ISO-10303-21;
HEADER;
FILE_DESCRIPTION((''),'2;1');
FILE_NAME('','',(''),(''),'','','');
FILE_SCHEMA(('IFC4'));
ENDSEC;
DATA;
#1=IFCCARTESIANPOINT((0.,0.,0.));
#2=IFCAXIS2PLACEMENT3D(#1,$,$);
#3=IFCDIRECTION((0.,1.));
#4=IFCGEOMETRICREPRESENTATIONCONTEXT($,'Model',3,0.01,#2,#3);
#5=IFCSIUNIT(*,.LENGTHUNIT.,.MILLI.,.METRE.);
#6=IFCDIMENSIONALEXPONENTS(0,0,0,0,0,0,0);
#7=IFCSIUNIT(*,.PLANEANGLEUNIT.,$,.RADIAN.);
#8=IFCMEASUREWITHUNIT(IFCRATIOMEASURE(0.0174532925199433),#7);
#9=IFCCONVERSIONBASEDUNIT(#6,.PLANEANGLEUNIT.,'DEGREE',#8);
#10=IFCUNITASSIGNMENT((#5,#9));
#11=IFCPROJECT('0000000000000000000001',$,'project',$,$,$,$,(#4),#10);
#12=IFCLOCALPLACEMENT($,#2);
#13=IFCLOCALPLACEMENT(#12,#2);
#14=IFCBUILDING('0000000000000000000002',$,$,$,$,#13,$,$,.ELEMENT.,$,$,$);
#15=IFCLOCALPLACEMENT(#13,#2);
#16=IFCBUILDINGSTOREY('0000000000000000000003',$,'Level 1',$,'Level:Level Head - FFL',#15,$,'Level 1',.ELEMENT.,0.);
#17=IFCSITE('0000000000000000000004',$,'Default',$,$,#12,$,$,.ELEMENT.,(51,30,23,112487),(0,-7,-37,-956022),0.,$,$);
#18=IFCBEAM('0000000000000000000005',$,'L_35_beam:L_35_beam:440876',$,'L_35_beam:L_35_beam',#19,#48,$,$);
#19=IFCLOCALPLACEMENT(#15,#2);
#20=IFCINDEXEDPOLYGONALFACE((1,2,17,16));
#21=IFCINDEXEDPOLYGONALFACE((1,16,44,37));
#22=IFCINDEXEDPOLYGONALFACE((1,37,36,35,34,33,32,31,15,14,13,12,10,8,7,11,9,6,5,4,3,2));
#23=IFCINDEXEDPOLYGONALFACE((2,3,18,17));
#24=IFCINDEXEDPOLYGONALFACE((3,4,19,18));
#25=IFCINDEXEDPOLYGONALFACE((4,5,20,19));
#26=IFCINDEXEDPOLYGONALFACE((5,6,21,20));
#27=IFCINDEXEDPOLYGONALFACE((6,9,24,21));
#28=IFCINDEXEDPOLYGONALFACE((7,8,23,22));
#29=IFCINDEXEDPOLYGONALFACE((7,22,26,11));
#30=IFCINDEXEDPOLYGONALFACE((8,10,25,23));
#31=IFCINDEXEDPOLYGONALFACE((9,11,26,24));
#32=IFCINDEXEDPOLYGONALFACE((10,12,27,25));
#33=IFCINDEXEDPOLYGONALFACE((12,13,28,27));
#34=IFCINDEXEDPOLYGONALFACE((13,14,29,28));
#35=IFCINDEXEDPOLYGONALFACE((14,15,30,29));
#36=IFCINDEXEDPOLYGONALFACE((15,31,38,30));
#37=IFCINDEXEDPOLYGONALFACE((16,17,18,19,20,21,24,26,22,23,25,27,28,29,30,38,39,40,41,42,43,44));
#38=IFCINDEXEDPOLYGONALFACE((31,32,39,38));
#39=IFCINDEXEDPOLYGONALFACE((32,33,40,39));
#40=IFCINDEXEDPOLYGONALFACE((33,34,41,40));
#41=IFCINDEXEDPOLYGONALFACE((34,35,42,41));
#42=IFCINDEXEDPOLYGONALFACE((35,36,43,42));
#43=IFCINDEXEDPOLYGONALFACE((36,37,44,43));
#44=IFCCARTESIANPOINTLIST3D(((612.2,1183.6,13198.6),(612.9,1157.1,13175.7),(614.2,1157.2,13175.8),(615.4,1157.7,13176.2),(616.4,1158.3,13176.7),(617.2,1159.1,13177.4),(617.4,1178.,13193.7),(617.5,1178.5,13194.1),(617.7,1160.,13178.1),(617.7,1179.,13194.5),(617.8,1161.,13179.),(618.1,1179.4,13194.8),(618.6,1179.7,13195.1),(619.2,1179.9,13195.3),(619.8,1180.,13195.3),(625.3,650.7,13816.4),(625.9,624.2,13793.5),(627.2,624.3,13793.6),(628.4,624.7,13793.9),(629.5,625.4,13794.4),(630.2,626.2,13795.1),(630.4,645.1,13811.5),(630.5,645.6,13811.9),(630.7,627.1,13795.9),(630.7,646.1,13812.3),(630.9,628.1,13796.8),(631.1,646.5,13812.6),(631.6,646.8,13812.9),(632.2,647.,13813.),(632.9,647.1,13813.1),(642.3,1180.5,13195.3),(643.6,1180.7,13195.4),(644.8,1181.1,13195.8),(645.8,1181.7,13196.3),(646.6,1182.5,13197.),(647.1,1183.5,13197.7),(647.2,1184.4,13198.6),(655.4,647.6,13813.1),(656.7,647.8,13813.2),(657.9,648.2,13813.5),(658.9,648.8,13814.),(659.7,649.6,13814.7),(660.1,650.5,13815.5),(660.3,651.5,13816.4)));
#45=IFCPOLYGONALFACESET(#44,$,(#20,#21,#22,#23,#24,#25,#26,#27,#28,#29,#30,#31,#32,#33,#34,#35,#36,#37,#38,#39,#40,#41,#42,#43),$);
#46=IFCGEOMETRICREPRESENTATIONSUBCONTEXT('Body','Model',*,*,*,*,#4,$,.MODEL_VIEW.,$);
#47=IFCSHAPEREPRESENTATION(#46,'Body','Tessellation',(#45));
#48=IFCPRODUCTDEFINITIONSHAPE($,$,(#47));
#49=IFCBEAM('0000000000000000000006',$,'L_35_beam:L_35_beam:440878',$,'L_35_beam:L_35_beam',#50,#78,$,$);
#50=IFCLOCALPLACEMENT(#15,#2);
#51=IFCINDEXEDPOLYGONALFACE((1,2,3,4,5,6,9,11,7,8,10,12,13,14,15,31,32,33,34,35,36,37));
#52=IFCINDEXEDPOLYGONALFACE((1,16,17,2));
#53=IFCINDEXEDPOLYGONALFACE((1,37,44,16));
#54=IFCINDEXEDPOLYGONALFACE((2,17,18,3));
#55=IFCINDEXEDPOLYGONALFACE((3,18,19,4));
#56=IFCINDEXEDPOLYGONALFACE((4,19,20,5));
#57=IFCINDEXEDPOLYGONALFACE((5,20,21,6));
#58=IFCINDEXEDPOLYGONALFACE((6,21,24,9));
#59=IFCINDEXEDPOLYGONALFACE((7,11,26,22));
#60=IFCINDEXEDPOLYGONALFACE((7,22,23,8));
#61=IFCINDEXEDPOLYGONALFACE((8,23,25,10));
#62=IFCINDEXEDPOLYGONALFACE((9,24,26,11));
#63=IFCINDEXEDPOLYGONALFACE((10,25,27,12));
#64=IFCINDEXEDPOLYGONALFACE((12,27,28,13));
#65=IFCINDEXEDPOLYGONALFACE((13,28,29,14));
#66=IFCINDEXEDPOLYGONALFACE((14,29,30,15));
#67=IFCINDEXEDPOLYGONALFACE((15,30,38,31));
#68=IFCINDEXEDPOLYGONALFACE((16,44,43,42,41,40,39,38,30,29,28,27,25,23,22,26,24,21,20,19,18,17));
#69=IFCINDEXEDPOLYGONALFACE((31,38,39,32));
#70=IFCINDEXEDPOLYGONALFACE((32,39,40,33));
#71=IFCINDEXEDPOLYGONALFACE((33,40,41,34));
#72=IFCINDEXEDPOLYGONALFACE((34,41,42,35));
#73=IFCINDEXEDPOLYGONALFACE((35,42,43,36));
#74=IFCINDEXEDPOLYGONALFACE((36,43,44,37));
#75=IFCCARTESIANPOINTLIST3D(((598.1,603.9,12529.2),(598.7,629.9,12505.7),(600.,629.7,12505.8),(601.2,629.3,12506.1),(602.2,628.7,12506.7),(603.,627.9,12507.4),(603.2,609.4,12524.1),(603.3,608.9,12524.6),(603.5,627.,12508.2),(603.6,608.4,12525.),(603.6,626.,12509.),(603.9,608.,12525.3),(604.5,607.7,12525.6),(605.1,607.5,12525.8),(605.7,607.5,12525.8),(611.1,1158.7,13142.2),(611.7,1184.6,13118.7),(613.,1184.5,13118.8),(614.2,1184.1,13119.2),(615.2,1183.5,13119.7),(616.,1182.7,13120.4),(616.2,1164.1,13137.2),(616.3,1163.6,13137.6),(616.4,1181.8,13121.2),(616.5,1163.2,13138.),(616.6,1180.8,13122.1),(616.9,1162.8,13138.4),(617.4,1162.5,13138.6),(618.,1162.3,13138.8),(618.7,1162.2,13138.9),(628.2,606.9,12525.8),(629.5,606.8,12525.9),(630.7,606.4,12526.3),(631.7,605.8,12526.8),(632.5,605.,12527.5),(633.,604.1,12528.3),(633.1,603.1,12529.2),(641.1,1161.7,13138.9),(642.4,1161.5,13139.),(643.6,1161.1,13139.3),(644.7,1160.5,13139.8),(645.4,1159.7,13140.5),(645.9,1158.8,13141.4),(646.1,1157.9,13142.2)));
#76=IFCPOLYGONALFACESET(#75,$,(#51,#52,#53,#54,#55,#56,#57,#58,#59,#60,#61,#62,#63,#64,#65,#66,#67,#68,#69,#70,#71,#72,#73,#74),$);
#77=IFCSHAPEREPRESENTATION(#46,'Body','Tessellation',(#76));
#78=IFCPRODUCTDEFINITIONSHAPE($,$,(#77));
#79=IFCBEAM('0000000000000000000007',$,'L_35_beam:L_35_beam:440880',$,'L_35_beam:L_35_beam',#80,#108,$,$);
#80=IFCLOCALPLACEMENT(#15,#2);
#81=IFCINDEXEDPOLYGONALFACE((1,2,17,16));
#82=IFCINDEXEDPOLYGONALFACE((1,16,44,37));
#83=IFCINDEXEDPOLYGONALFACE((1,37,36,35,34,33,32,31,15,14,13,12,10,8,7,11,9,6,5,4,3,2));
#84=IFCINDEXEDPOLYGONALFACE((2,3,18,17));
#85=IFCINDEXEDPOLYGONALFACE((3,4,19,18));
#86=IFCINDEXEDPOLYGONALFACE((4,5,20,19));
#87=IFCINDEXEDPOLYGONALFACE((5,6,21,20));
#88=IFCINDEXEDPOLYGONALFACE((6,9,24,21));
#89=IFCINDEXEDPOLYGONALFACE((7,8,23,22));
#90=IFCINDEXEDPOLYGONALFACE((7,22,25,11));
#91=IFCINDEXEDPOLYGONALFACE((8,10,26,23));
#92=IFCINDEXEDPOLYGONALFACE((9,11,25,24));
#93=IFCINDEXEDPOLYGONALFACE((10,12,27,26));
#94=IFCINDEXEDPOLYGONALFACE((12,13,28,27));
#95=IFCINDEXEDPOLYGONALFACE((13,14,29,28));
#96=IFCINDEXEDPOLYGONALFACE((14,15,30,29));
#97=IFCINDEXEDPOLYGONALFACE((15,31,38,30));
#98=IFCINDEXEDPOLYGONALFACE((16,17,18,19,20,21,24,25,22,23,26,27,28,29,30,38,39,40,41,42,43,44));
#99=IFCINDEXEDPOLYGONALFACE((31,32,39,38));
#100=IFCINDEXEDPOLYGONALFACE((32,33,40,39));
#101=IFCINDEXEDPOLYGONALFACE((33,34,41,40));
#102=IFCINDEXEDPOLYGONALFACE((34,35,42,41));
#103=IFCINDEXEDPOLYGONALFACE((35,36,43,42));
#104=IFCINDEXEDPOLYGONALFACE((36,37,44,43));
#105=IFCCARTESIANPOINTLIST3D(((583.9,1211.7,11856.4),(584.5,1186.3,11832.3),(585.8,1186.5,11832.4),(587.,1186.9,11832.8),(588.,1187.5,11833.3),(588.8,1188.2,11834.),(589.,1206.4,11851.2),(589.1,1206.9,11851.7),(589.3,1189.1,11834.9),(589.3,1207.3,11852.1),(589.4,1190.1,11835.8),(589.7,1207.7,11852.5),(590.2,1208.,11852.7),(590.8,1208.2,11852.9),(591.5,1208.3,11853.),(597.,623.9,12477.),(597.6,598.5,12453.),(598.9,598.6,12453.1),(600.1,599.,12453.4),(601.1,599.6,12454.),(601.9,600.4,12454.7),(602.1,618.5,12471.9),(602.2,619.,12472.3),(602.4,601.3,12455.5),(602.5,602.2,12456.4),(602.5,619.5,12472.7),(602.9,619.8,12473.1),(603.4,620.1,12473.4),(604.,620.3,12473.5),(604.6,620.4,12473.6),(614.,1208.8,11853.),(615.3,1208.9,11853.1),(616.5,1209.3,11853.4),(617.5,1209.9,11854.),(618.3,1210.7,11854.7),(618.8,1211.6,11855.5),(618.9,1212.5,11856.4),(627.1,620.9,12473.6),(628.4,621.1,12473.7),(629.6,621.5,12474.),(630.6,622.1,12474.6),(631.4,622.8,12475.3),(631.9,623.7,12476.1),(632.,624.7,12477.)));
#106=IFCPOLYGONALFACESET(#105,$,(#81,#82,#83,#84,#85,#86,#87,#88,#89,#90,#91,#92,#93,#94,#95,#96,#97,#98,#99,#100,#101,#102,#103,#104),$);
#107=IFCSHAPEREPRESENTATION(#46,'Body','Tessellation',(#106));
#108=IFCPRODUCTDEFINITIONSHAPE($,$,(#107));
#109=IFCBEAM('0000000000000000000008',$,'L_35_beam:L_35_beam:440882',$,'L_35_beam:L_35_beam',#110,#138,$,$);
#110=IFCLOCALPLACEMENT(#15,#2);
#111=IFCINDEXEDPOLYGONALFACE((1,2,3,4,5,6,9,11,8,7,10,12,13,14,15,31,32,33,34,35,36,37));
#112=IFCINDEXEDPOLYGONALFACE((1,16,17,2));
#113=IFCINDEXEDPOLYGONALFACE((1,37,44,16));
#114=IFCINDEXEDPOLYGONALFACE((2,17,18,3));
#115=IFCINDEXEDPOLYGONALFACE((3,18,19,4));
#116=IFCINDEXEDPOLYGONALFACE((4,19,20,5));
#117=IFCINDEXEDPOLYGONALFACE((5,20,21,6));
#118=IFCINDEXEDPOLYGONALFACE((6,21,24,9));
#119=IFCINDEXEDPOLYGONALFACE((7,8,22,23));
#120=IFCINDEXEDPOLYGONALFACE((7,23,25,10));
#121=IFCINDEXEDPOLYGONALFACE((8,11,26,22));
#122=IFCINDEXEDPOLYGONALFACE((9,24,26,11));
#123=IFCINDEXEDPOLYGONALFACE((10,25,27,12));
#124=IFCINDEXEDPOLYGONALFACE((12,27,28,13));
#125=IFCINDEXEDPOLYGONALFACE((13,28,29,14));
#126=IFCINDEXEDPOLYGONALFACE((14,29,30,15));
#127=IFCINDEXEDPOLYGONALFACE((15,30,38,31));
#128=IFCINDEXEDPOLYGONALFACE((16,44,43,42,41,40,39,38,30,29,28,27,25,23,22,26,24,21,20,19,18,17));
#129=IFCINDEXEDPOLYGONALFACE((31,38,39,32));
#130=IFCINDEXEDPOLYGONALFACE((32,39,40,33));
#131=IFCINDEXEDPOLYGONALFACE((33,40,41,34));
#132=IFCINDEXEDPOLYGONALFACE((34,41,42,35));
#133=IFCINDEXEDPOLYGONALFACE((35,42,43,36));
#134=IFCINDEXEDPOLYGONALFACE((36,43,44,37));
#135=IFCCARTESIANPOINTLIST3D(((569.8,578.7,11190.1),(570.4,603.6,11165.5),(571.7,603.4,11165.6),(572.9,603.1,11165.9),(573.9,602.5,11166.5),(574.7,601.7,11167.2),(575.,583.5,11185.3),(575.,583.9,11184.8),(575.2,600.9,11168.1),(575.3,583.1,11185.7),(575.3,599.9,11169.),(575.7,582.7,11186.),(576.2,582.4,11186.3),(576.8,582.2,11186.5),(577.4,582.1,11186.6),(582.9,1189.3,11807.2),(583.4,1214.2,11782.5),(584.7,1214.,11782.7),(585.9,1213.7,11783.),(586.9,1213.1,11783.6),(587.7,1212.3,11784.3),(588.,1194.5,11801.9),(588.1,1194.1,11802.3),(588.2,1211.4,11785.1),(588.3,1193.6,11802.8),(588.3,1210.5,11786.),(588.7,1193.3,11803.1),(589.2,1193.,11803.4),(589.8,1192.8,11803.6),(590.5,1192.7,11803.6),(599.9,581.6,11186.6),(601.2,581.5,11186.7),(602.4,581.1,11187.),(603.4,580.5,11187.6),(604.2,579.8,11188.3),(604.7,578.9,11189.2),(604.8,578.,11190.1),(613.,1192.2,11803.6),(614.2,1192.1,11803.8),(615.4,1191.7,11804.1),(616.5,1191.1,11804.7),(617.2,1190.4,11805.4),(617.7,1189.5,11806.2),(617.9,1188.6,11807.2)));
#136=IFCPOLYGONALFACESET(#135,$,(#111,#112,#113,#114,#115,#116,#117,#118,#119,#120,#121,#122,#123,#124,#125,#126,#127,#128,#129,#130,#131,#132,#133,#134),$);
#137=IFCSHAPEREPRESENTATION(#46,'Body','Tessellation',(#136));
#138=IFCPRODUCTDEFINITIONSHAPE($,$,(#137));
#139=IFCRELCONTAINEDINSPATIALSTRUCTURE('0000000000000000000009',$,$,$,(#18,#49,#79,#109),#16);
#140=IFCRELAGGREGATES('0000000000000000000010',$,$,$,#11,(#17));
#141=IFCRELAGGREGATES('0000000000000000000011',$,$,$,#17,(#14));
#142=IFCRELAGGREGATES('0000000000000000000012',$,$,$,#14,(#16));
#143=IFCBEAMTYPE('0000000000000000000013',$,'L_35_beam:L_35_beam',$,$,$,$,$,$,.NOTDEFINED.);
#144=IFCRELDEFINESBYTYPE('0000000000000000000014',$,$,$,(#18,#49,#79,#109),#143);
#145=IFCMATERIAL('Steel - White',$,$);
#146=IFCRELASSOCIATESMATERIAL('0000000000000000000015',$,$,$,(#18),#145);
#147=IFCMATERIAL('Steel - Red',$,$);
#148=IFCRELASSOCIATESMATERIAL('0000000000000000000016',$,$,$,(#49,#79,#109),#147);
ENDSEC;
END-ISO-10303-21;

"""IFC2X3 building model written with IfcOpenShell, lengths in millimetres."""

from ifc_helpers import new_model, entity, si_unit, converted_unit, direction, frame, frame_2d, origin, place, context, subcontext, project, spatial, polyline, circle_curve, parameter, trimmed, segment, composite_curve, outline, extrude, material, type_object, element, save


model = new_model("IFC2X3")

# Units and contexts
model_context = context("Model", 3, precision=0.01, world=origin(), true_north=direction((0.0, 1.0)))
body_context = subcontext(model_context, "Body", "Model", "MODEL_VIEW")
ifc_project = project(units=[si_unit("LENGTHUNIT", "METRE", prefix="MILLI"), converted_unit("PLANEANGLEUNIT", "DEGREE", entity("IfcRatioMeasure", 0.0174532925199433), si_unit("PLANEANGLEUNIT", "RADIAN"), dimensions=[0, 0, 0, 0, 0, 0, 0])], contexts=[model_context])

# Site, building, storey
site_placement = place(None, origin())
site = spatial("IfcSite", under=ifc_project, at=site_placement, Name="Default", CompositionType="ELEMENT", RefLatitude=(51, 30, 23, 112487), RefLongitude=(0, -7, -37, -956022), RefElevation=0.0)
building_placement = place(site_placement, origin())
building = spatial("IfcBuilding", under=site, at=building_placement, CompositionType="ELEMENT")
storey_placement = place(building_placement, origin())
storey = spatial("IfcBuildingStorey", under=building, at=storey_placement, Name="Level 1", ObjectType="Level:Level Head - FFL", LongName="Level 1", CompositionType="ELEMENT", Elevation=0.0)

# Beams
ifc_material_1 = material(Name="Steel - Red")
ifc_material_2 = material(Name="Steel - White")
beam_type_1 = type_object("IfcBeamType", Name="L_35_beam:L_35_beam", PredefinedType="NOTDEFINED")
beam_1_placement = place(storey_placement, frame((618.1, 618.2, 13827.0), z_axis=(0.999872, 0.010449, -0.012113), x_axis=(-0.015997, 0.653107, -0.757096)))
element("IfcBeam", 1, at=beam_1_placement, inside=storey, type_object=beam_type_1, material=ifc_material_2, Name="L_35_beam:L_35_beam:440876", ObjectType="L_35_beam:L_35_beam", context=body_context, shape_type="SweptSolid", body=[
    extrude(outline(composite_curve([segment(polyline([(-11.8, -11.8), (23.2, -11.8)]), True, "CONTINUOUS"), segment(trimmed(circle_curve(frame_2d((18.2, -11.8), x_axis=(1.0, 0.0)), 5.0), [parameter(0.0)], [parameter(90.0)], True, "PARAMETER"), True, "CONTINUOUS"), segment(polyline([(18.2, -6.8), (-4.3, -6.8)]), True, "CONTINUOUS"), segment(trimmed(circle_curve(frame_2d((-4.3, -4.3), x_axis=(0.0, -1.0)), 2.5), [parameter(270.0)], [parameter(0.0)], True, "PARAMETER"), False, "CONTINUOUS"), segment(polyline([(-6.8, -4.3), (-6.8, 18.2)]), True, "CONTINUOUS"), segment(trimmed(circle_curve(frame_2d((-11.8, 18.2), x_axis=(1.0, 0.0)), 5.0), [parameter(0.0)], [parameter(90.0)], True, "PARAMETER"), True, "CONTINUOUS"), segment(polyline([(-11.8, 23.2), (-11.8, -11.8)]), True, "CONTINUOUS")], self_intersect=False)), frame((29.2, 6.1, 19.7), z_axis=(1.0, 0.0, 0.0), x_axis=(0.0, 0.018541, 0.999828)), (0.0, 0.0, 1.0), 816.0),
])
beam_2_placement = place(storey_placement, frame((589.8, 589.8, 12487.3), z_axis=(0.999877, -0.010511, -0.011615), x_axis=(0.015665, 0.670902, 0.741381)))
element("IfcBeam", 2, at=beam_2_placement, inside=storey, type_object=beam_type_1, material=ifc_material_1, Name="L_35_beam:L_35_beam:440878", ObjectType="L_35_beam:L_35_beam", context=body_context, shape_type="SweptSolid", body=[
    extrude(outline(composite_curve([segment(polyline([(-11.8, -11.8), (23.2, -11.8)]), True, "CONTINUOUS"), segment(trimmed(circle_curve(frame_2d((18.2, -11.8), x_axis=(1.0, 0.0)), 5.0), [parameter(0.0)], [parameter(90.0)], True, "PARAMETER"), True, "CONTINUOUS"), segment(polyline([(18.2, -6.8), (-4.3, -6.8)]), True, "CONTINUOUS"), segment(trimmed(circle_curve(frame_2d((-4.3, -4.3), x_axis=(0.0, -1.0)), 2.5), [parameter(270.0)], [parameter(0.0)], True, "PARAMETER"), False, "CONTINUOUS"), segment(polyline([(-6.8, -4.3), (-6.8, 18.2)]), True, "CONTINUOUS"), segment(trimmed(circle_curve(frame_2d((-11.8, 18.2), x_axis=(1.0, 0.0)), 5.0), [parameter(0.0)], [parameter(90.0)], True, "PARAMETER"), True, "CONTINUOUS"), segment(polyline([(-11.8, 23.2), (-11.8, -11.8)]), True, "CONTINUOUS")], self_intersect=False)), frame((40.6, 6.1, 19.7), z_axis=(1.0, 0.0, 0.0), x_axis=(0.0, 0.017308, 0.99985)), (0.0, 0.0, 1.0), 826.9),
])
beam_3_placement = place(storey_placement, frame((589.8, 589.8, 12487.3), z_axis=(0.999882, 0.010548, -0.011136), x_axis=(-0.015339, 0.687593, -0.725934)))
element("IfcBeam", 3, at=beam_3_placement, inside=storey, type_object=beam_type_1, material=ifc_material_1, Name="L_35_beam:L_35_beam:440880", ObjectType="L_35_beam:L_35_beam", context=body_context, shape_type="SweptSolid", body=[
    extrude(outline(composite_curve([segment(polyline([(-11.8, -11.8), (23.2, -11.8)]), True, "CONTINUOUS"), segment(trimmed(circle_curve(frame_2d((18.2, -11.8), x_axis=(1.0, 0.0)), 5.0), [parameter(0.0)], [parameter(90.0)], True, "PARAMETER"), True, "CONTINUOUS"), segment(polyline([(18.2, -6.8), (-4.3, -6.8)]), True, "CONTINUOUS"), segment(trimmed(circle_curve(frame_2d((-4.3, -4.3), x_axis=(0.0, -1.0)), 2.5), [parameter(270.0)], [parameter(0.0)], True, "PARAMETER"), False, "CONTINUOUS"), segment(polyline([(-6.8, -4.3), (-6.8, 18.2)]), True, "CONTINUOUS"), segment(trimmed(circle_curve(frame_2d((-11.8, 18.2), x_axis=(1.0, 0.0)), 5.0), [parameter(0.0)], [parameter(90.0)], True, "PARAMETER"), True, "CONTINUOUS"), segment(polyline([(-11.8, 23.2), (-11.8, -11.8)]), True, "CONTINUOUS")], self_intersect=False)), frame((30.8, 6.0, 19.7), z_axis=(1.0, 0.0, 0.0), x_axis=(0.0, 0.016192, 0.999869)), (0.0, 0.0, 1.0), 854.9),
])
beam_4_placement = place(storey_placement, frame((561.5, 561.5, 11147.6), z_axis=(0.999887, -0.010563, -0.010676), x_axis=(0.015018, 0.703278, 0.710756)))
element("IfcBeam", 4, at=beam_4_placement, inside=storey, type_object=beam_type_1, material=ifc_material_1, Name="L_35_beam:L_35_beam:440882", ObjectType="L_35_beam:L_35_beam", context=body_context, shape_type="SweptSolid", body=[
    extrude(outline(composite_curve([segment(polyline([(-11.8, -11.8), (23.2, -11.8)]), True, "CONTINUOUS"), segment(trimmed(circle_curve(frame_2d((18.2, -11.8), x_axis=(1.0, 0.0)), 5.0), [parameter(0.0)], [parameter(90.0)], True, "PARAMETER"), True, "CONTINUOUS"), segment(polyline([(18.2, -6.8), (-4.3, -6.8)]), True, "CONTINUOUS"), segment(trimmed(circle_curve(frame_2d((-4.3, -4.3), x_axis=(0.0, -1.0)), 2.5), [parameter(270.0)], [parameter(0.0)], True, "PARAMETER"), False, "CONTINUOUS"), segment(polyline([(-6.8, -4.3), (-6.8, 18.2)]), True, "CONTINUOUS"), segment(trimmed(circle_curve(frame_2d((-11.8, 18.2), x_axis=(1.0, 0.0)), 5.0), [parameter(0.0)], [parameter(90.0)], True, "PARAMETER"), True, "CONTINUOUS"), segment(polyline([(-11.8, 23.2), (-11.8, -11.8)]), True, "CONTINUOUS")], self_intersect=False)), frame((42.4, 6.0, 19.7), z_axis=(1.0, 0.0, 0.0), x_axis=(0.0, 0.015176, 0.999885)), (0.0, 0.0, 1.0), 868.2),
])

save(model, "model.ifc")
